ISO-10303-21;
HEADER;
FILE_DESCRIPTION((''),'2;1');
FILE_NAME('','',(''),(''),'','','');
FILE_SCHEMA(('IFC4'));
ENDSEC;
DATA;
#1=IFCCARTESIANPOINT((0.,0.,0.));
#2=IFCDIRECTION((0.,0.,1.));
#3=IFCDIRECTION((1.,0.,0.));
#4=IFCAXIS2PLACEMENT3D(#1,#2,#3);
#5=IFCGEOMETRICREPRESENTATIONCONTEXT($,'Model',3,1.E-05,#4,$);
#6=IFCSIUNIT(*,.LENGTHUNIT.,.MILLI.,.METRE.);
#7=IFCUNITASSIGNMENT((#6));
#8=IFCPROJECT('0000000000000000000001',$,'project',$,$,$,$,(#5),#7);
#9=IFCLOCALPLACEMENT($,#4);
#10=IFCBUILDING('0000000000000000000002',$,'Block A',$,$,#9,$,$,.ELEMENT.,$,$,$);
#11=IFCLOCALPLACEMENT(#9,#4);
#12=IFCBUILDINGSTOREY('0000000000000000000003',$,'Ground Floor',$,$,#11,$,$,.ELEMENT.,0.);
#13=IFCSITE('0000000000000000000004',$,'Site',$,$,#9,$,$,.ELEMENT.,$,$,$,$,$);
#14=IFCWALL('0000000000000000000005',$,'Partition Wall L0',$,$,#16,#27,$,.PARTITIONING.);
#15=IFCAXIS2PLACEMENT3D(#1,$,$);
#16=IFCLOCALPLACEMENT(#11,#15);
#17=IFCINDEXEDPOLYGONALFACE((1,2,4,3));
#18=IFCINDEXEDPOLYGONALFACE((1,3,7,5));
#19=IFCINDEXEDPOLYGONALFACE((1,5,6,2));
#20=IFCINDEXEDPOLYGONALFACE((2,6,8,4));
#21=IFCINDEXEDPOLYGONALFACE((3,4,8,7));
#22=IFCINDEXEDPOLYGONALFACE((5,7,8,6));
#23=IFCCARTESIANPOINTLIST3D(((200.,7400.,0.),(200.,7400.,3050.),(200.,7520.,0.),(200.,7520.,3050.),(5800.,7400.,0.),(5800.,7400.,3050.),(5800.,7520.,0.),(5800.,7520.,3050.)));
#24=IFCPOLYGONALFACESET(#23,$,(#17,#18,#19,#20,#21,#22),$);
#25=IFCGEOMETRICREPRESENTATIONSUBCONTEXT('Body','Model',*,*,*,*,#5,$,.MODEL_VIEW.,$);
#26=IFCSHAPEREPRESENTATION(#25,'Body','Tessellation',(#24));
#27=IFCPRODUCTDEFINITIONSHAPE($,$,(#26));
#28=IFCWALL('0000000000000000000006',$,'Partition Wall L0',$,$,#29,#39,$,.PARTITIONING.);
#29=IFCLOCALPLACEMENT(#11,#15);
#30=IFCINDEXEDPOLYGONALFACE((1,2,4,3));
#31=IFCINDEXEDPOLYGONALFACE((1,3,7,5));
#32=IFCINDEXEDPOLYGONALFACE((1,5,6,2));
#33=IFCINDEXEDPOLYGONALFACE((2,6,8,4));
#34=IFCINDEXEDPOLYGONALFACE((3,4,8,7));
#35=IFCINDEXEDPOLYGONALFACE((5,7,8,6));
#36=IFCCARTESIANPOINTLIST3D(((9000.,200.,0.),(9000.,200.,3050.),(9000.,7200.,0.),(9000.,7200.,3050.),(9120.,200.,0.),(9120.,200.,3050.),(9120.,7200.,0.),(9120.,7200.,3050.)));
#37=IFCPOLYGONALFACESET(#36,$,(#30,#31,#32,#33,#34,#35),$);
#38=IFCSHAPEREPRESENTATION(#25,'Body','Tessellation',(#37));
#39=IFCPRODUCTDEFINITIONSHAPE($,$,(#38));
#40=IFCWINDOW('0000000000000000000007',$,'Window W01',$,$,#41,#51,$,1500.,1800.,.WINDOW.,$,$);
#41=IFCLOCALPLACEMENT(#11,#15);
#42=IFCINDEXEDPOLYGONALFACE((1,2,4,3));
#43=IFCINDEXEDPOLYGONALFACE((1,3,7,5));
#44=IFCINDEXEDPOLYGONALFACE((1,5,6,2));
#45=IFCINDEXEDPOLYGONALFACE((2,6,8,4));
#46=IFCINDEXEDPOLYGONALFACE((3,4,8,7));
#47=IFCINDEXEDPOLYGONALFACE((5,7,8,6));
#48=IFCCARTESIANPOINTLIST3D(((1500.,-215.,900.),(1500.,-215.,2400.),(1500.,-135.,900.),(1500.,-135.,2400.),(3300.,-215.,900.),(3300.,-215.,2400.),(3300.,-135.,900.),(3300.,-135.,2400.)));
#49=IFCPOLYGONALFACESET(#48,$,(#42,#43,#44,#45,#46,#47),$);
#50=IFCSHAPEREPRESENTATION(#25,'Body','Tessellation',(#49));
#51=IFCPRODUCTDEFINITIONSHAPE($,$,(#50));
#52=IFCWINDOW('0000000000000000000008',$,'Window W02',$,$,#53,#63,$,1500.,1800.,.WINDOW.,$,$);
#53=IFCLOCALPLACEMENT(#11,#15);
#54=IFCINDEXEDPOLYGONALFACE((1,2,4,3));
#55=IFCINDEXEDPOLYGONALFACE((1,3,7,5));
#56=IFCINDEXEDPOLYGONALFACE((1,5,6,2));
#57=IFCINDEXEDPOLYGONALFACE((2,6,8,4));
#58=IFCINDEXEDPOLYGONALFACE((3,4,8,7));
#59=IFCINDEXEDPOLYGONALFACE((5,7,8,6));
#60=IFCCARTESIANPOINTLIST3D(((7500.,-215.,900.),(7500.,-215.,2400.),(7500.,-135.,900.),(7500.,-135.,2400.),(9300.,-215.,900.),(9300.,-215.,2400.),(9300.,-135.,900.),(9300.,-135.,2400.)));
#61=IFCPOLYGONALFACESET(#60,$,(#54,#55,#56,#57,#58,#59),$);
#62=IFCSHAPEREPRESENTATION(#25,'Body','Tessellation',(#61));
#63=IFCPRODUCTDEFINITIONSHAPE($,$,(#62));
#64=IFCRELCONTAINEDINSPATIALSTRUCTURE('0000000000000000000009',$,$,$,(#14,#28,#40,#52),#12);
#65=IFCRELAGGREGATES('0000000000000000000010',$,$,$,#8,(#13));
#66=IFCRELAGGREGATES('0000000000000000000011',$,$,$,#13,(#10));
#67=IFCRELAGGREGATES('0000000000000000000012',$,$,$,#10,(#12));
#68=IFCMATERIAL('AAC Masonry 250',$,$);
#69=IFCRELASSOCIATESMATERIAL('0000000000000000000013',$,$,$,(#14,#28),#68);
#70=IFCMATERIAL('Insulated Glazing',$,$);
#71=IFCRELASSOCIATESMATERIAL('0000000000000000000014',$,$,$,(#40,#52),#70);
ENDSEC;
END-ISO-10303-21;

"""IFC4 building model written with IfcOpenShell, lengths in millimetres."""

from ifc_helpers import new_model, si_unit, frame, frame_2d, origin_with_axes, place, context, subcontext, project, spatial, rectangle, extrude, material, element, save


model = new_model("IFC4")

# Units and contexts
model_context = context("Model", 3, precision=1e-05, world=origin_with_axes())
body_context = subcontext(model_context, "Body", "Model", "MODEL_VIEW")
ifc_project = project(units=[si_unit("LENGTHUNIT", "METRE", prefix="MILLI")], contexts=[model_context])

# Site, building, storey
placement = place(None, origin_with_axes())
site = spatial("IfcSite", under=ifc_project, at=placement, Name="Site", CompositionType="ELEMENT")
building = spatial("IfcBuilding", under=site, at=placement, Name="Block A", CompositionType="ELEMENT")
storey_placement = place(placement, origin_with_axes())
storey = spatial("IfcBuildingStorey", under=building, at=storey_placement, Name="Ground Floor", CompositionType="ELEMENT", Elevation=0.0)

# Walls
ifc_material_1 = material(Name="AAC Masonry 250")
wall_1_placement = place(placement, frame((200.0, 7400.0, 0.0), z_axis=(0.0, 0.0, 1.0), x_axis=(1.0, 0.0, 0.0)))
element("IfcWall", 1, at=wall_1_placement, inside=storey, material=ifc_material_1, Name="Partition Wall L0", PredefinedType="PARTITIONING", context=body_context, shape_type="SweptSolid", body=[
    extrude(rectangle(XDim=5600.0, YDim=120.0, at=frame_2d((2800.0, 60.0))), origin_with_axes(), (0.0, 0.0, 1.0), 3050.0),
])
wall_2_placement = place(placement, frame((9000.0, 200.0, 0.0), z_axis=(0.0, 0.0, 1.0), x_axis=(1.0, 0.0, 0.0)))
element("IfcWall", 2, at=wall_2_placement, inside=storey, material=ifc_material_1, Name="Partition Wall L0", PredefinedType="PARTITIONING", context=body_context, shape_type="SweptSolid", body=[
    extrude(rectangle(XDim=120.0, YDim=7000.0, at=frame_2d((60.0, 3500.0))), origin_with_axes(), (0.0, 0.0, 1.0), 3050.0),
])

# Windows
ifc_material_2 = material(Name="Insulated Glazing")
for number, where, z_axis, x_axis, name in (
    (3, (1500.0, -215.0, 900.0), (0.0, 0.0, 1.0), (1.0, 0.0, 0.0), "Window W01"),
    (4, (7500.0, -215.0, 900.0), (0.0, 0.0, 1.0), (1.0, 0.0, 0.0), "Window W02"),
):
    element("IfcWindow", number, at=place(placement, frame(where, z_axis=z_axis, x_axis=x_axis)), inside=storey, material=ifc_material_2, Name=name, OverallHeight=1500.0, OverallWidth=1800.0, PredefinedType="WINDOW", context=body_context, shape_type="SweptSolid", body=[
        extrude(rectangle(XDim=1800.0, YDim=80.0, at=frame_2d((900.0, 40.0))), origin_with_axes(), (0.0, 0.0, 1.0), 1500.0),
    ])

save(model, "model.ifc")
